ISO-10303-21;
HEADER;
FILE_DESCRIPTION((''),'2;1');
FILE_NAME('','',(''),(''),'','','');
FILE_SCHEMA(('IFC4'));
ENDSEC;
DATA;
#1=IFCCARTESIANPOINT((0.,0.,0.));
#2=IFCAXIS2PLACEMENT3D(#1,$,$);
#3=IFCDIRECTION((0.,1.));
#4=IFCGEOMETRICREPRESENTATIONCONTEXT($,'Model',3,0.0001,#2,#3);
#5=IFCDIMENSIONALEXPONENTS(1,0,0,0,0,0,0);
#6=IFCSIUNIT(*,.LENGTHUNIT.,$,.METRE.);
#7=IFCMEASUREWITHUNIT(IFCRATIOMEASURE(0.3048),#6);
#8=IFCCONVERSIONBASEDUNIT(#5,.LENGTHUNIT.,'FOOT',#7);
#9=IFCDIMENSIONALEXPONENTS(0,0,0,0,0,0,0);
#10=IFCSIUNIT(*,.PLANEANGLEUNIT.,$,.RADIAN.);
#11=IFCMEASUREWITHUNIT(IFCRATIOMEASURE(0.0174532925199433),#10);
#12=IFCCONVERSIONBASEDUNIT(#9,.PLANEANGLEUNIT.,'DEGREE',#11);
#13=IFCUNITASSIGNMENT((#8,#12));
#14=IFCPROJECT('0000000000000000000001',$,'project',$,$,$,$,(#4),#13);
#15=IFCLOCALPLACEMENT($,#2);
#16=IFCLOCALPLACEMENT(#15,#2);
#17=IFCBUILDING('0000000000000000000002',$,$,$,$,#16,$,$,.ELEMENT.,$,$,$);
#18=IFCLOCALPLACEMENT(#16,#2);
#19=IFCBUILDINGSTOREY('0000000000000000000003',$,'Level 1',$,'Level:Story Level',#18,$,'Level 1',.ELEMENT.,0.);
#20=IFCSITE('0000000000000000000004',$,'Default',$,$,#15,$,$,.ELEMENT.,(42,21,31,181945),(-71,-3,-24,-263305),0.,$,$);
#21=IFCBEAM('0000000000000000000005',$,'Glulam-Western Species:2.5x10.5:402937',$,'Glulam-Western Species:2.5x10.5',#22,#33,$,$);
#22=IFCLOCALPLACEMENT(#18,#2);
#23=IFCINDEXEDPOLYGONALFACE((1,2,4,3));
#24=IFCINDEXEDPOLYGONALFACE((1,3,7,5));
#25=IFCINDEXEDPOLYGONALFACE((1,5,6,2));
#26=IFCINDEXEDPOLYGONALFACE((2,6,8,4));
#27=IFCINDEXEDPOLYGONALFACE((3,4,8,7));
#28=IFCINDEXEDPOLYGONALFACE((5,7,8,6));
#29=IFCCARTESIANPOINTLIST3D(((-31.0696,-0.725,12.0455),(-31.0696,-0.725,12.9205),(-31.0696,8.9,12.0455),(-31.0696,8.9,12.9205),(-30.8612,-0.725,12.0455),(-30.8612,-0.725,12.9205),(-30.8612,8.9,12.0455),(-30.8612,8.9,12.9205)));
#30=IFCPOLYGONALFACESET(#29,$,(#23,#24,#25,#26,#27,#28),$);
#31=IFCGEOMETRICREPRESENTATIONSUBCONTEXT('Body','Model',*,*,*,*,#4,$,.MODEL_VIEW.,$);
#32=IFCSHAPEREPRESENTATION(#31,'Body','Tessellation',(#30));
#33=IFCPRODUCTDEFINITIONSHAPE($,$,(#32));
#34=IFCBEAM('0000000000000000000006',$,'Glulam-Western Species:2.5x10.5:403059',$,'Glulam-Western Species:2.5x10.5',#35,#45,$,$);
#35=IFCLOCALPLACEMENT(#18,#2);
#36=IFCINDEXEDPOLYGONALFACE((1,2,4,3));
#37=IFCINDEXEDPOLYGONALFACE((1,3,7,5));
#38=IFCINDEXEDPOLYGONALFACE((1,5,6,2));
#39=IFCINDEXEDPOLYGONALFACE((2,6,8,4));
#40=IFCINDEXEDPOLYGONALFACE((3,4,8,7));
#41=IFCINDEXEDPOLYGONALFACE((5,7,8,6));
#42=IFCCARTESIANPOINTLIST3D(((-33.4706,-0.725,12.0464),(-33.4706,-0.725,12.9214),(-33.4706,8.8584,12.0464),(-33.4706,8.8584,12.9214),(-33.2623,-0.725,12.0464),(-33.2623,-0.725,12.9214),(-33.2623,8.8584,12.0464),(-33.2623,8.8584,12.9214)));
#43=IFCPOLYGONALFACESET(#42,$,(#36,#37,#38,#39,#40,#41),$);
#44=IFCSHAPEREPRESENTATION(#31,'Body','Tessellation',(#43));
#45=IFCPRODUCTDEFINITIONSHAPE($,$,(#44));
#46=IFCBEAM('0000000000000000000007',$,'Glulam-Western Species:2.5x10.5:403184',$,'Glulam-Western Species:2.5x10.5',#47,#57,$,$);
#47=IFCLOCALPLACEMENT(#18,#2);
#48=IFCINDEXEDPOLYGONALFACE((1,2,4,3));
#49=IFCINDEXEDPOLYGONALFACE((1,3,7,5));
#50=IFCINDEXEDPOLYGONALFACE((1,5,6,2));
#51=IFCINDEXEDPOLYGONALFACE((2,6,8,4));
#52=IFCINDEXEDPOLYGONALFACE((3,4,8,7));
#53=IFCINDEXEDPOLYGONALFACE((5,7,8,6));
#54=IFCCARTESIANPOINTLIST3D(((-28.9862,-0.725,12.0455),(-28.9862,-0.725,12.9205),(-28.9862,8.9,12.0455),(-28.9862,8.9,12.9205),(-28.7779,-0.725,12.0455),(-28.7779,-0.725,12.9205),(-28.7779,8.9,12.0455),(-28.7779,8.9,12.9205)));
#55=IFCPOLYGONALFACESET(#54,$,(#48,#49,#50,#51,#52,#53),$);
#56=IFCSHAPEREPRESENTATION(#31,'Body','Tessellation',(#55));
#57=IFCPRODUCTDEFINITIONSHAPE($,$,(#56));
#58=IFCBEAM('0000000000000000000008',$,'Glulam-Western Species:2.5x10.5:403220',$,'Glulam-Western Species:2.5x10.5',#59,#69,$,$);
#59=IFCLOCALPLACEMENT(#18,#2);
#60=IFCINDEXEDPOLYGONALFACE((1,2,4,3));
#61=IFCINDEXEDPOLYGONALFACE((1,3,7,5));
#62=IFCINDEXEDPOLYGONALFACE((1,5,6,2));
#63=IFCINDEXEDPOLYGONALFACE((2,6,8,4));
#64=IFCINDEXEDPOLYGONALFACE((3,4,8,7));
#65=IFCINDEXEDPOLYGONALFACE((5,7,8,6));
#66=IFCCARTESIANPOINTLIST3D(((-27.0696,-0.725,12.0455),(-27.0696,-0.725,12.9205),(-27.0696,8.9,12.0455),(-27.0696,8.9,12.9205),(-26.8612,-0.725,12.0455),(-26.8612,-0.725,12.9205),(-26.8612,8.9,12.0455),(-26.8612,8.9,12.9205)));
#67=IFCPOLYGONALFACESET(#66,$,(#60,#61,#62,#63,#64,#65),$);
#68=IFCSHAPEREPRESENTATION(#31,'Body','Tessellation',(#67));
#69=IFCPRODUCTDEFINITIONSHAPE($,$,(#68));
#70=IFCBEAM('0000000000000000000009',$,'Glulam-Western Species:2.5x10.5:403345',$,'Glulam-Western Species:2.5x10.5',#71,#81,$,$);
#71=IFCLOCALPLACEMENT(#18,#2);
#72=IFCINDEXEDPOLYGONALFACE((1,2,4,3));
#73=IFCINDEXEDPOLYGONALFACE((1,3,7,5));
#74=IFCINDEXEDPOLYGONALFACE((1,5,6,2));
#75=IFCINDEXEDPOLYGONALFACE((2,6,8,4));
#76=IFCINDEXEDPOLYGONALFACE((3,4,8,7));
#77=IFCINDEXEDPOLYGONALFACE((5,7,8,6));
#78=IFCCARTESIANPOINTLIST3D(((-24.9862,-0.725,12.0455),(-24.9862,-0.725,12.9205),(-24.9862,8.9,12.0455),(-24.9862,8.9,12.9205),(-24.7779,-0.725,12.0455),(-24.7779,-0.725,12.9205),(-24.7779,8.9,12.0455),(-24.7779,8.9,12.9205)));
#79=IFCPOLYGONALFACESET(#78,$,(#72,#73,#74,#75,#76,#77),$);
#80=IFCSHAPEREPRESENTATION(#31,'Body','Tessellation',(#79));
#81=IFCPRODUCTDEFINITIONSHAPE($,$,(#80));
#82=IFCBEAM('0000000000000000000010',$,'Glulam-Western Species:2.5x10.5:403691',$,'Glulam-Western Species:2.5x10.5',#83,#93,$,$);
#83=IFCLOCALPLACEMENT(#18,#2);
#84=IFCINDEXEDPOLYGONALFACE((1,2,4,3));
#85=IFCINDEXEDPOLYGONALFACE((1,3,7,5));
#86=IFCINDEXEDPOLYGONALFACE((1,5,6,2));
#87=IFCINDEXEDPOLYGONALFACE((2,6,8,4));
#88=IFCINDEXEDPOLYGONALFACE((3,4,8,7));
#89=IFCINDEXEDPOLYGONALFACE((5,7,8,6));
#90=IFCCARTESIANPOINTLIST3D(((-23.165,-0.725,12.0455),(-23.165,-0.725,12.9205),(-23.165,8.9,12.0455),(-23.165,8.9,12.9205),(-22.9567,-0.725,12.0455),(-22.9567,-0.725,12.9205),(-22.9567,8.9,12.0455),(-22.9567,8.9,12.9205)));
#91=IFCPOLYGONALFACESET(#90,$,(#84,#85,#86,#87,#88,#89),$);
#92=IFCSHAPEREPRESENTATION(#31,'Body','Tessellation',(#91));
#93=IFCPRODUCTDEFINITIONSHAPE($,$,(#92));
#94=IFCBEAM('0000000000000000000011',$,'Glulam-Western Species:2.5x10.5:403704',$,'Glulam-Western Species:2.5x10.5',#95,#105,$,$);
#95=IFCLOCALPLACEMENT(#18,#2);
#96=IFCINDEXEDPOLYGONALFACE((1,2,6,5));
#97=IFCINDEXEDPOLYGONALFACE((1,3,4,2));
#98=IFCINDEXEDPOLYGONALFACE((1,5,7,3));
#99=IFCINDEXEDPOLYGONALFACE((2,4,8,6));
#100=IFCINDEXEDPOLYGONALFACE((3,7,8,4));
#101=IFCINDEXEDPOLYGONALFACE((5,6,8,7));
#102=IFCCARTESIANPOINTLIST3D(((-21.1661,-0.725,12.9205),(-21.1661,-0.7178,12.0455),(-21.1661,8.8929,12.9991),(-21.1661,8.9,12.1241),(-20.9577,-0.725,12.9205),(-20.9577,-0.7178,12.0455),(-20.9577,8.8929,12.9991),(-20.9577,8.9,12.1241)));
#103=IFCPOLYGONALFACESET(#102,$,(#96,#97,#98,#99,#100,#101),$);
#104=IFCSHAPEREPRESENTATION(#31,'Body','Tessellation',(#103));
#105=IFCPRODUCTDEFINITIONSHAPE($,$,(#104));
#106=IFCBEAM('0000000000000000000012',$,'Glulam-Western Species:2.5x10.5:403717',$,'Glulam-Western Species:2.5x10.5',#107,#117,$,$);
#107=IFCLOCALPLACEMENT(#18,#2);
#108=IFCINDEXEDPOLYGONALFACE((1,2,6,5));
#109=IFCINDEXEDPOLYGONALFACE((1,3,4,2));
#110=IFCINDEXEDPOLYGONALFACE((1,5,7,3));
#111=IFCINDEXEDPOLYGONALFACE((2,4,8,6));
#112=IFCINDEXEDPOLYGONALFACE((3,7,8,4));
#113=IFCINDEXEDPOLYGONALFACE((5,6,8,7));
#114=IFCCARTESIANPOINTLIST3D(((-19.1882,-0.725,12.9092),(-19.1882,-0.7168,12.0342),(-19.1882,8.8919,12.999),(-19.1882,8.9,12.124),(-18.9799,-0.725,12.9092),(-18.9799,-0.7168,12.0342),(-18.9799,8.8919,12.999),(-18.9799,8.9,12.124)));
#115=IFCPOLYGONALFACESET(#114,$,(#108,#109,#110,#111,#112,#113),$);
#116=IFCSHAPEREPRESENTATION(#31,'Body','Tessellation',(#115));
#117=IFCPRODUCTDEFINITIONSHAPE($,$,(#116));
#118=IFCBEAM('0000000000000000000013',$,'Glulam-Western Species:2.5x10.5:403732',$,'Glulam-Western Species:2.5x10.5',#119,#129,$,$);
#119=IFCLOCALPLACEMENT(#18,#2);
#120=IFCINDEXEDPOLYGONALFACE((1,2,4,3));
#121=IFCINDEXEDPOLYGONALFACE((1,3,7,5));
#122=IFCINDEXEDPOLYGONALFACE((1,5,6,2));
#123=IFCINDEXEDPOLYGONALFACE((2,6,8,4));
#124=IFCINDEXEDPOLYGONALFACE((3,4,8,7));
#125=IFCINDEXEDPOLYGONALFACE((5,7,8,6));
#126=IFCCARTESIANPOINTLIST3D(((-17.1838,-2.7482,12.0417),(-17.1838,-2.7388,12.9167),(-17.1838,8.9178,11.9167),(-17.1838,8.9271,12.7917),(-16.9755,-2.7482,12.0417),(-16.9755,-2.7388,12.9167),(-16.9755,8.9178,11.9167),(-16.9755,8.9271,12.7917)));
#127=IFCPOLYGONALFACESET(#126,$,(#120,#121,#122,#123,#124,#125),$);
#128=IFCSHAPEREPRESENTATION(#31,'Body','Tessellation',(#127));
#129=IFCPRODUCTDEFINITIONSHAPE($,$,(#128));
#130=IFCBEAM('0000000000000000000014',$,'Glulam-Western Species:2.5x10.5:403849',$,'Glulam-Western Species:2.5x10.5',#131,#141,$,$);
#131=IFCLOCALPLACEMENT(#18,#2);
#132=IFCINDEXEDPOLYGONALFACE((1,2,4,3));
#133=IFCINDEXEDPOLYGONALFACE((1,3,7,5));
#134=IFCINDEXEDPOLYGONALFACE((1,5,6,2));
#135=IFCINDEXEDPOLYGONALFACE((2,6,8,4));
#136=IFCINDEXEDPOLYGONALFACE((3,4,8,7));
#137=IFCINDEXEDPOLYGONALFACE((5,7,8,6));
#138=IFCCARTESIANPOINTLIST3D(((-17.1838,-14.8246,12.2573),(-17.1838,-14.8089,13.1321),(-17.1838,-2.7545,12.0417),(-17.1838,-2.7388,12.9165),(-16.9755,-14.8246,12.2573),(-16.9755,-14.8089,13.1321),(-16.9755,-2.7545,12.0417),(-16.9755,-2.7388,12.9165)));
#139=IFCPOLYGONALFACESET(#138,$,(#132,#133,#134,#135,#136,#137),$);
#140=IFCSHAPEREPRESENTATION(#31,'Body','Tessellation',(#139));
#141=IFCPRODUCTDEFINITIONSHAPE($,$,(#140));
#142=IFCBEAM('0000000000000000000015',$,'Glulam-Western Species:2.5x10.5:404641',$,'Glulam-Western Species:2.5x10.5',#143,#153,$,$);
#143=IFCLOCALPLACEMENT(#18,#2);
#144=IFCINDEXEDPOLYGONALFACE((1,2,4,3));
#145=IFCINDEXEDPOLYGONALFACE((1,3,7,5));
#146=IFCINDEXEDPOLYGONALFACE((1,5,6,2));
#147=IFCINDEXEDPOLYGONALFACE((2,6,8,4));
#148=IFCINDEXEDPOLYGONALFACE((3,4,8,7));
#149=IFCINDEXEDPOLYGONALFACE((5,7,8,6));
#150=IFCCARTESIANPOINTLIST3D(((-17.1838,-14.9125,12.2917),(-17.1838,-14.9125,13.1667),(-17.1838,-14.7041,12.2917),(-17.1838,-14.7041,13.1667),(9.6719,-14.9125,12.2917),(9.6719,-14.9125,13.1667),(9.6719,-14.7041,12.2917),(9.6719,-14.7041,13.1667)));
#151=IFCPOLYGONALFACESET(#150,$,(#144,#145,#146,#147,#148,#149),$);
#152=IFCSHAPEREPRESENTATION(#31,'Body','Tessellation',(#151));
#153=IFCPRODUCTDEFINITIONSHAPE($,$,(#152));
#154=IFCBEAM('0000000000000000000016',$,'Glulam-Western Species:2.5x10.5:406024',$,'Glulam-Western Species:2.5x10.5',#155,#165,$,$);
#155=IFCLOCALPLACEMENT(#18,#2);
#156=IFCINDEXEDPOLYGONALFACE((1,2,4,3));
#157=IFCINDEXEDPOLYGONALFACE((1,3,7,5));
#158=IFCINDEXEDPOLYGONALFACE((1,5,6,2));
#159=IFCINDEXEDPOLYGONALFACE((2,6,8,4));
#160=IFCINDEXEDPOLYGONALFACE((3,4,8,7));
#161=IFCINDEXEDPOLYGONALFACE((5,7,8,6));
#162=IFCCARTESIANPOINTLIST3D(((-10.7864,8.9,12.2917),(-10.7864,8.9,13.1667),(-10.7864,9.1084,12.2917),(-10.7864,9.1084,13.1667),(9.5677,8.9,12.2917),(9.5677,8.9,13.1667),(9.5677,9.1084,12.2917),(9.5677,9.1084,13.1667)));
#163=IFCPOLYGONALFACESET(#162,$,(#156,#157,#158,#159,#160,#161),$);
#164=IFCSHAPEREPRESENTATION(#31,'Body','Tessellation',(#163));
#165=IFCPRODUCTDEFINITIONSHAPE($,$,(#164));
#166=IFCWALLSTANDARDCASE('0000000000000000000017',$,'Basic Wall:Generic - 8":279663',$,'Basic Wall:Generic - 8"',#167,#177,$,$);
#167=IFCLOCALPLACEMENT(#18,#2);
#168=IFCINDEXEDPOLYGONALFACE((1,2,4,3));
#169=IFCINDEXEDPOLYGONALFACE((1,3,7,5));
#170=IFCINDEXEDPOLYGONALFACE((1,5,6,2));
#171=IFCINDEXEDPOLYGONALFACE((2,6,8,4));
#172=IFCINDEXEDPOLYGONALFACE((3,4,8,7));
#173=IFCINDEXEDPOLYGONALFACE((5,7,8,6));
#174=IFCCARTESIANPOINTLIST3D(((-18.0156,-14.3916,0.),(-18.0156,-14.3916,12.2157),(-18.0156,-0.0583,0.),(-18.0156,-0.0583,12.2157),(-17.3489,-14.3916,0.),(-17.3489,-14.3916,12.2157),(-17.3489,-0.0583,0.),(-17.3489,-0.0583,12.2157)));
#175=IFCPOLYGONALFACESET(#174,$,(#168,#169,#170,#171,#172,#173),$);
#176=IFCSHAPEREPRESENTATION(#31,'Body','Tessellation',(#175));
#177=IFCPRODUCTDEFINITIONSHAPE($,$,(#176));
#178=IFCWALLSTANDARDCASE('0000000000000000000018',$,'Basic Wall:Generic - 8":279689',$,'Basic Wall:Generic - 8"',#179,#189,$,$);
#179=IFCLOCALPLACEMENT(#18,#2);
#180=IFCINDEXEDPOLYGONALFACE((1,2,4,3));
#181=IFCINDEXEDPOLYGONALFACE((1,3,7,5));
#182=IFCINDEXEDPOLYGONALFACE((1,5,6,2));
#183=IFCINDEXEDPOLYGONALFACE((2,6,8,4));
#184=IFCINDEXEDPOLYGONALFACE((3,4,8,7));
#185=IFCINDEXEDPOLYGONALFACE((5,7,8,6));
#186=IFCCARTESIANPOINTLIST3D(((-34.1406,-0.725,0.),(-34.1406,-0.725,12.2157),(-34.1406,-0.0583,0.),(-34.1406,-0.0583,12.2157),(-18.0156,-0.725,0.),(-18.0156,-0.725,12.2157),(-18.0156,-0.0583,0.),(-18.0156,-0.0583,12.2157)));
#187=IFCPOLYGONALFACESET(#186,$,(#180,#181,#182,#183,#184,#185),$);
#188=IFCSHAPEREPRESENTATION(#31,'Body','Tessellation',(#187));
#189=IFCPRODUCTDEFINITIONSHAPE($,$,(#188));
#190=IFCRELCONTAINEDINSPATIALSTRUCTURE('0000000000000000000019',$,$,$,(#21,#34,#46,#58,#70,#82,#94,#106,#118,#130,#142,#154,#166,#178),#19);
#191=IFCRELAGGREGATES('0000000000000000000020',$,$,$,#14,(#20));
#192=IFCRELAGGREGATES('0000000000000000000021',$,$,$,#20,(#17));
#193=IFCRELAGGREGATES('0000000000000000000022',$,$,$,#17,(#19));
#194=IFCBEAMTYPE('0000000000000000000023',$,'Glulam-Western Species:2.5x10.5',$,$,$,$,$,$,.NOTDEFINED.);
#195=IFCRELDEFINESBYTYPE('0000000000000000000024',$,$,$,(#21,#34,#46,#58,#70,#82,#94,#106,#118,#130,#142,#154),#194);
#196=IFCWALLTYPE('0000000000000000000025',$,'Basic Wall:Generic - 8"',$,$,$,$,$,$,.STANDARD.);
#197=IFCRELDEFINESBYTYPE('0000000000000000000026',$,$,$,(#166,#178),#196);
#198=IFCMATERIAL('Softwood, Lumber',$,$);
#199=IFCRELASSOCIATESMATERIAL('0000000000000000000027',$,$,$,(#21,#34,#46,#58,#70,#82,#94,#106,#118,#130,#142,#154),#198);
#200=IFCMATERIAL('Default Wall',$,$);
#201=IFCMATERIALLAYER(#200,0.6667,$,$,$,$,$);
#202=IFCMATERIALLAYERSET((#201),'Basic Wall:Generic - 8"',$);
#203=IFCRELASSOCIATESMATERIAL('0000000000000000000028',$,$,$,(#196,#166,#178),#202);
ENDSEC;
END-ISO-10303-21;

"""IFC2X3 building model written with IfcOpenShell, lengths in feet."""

from ifc_helpers import new_model, entity, si_unit, converted_unit, direction, frame, frame_2d, origin, origin_2d_with_axis, place, context, subcontext, project, spatial, rectangle, extrude, material, layer, layer_set, layer_usage, type_object, element, save


model = new_model("IFC2X3")

# Units and contexts
model_context = context("Model", 3, precision=0.0001, world=origin(), true_north=direction((0.0, 1.0)))
body_context = subcontext(model_context, "Body", "Model", "MODEL_VIEW")
ifc_project = project(units=[converted_unit("LENGTHUNIT", "FOOT", entity("IfcRatioMeasure", 0.3048), si_unit("LENGTHUNIT", "METRE"), dimensions=[1, 0, 0, 0, 0, 0, 0]), converted_unit("PLANEANGLEUNIT", "DEGREE", entity("IfcRatioMeasure", 0.0174532925199433), si_unit("PLANEANGLEUNIT", "RADIAN"), dimensions=[0, 0, 0, 0, 0, 0, 0])], contexts=[model_context])

# Site, building, storey
site_placement = place(None, origin())
site = spatial("IfcSite", under=ifc_project, at=site_placement, Name="Default", CompositionType="ELEMENT", RefLatitude=(42, 21, 31, 181945), RefLongitude=(-71, -3, -24, -263305), RefElevation=0.0)
building_placement = place(site_placement, origin())
building = spatial("IfcBuilding", under=site, at=building_placement, CompositionType="ELEMENT")
storey_placement = place(building_placement, origin())
storey = spatial("IfcBuildingStorey", under=building, at=storey_placement, Name="Level 1", ObjectType="Level:Story Level", LongName="Level 1", CompositionType="ELEMENT", Elevation=0.0)

# Beams
ifc_material_1 = material(Name="Softwood, Lumber")
beam_type = type_object("IfcBeamType", Name="Glulam-Western Species:2.5x10.5", PredefinedType="NOTDEFINED")
beam_1_placement = place(storey_placement, frame((-30.9654, 8.6084, 12.9205), z_axis=(0.0, 0.0, 1.0), x_axis=(0.0, -1.0, 0.0)))
element("IfcBeam", 1, at=beam_1_placement, inside=storey, type_object=beam_type, material=ifc_material_1, Name="Glulam-Western Species:2.5x10.5:402937", ObjectType="Glulam-Western Species:2.5x10.5", context=body_context, shape_type="SweptSolid", body=[
    extrude(rectangle(XDim=0.875, YDim=0.2083, at=frame_2d((0.0, 0.0), x_axis=(1.0, 0.0))), frame((-0.2917, 0.0, -0.4375), z_axis=(1.0, 0.0, 0.0), x_axis=(0.0, 0.0, -1.0)), (0.0, 0.0, 1.0), 9.625),
])
beam_2_placement = place(storey_placement, frame((-33.3665, 8.8584, 12.9214), z_axis=(0.0, 0.0, 1.0), x_axis=(0.0, -1.0, 0.0)))
element("IfcBeam", 2, at=beam_2_placement, inside=storey, type_object=beam_type, material=ifc_material_1, Name="Glulam-Western Species:2.5x10.5:403059", ObjectType="Glulam-Western Species:2.5x10.5", context=body_context, shape_type="SweptSolid", body=[
    extrude(rectangle(XDim=0.875, YDim=0.2083, at=frame_2d((0.0, 0.0), x_axis=(1.0, 0.0))), frame((0.0, 0.0, -0.4375), z_axis=(1.0, 0.0, 0.0), x_axis=(0.0, 0.0, -1.0)), (0.0, 0.0, 1.0), 9.5833),
])
beam_3_placement = place(storey_placement, frame((-28.8821, 8.6084, 12.9205), z_axis=(0.0, 0.0, 1.0), x_axis=(0.0, -1.0, 0.0)))
element("IfcBeam", 3, at=beam_3_placement, inside=storey, type_object=beam_type, material=ifc_material_1, Name="Glulam-Western Species:2.5x10.5:403184", ObjectType="Glulam-Western Species:2.5x10.5", context=body_context, shape_type="SweptSolid", body=[
    extrude(rectangle(XDim=0.875, YDim=0.2083, at=frame_2d((0.0, 0.0), x_axis=(1.0, 0.0))), frame((-0.2917, 0.0, -0.4375), z_axis=(1.0, 0.0, 0.0), x_axis=(0.0, 0.0, -1.0)), (0.0, 0.0, 1.0), 9.625),
])
for number, where, z_axis, x_axis, name in (
    (4, (-26.9654, 8.6084, 12.9205), (0.0, 0.0, 1.0), (0.0, -1.0, 0.0), "Glulam-Western Species:2.5x10.5:403220"),
    (5, (-24.8821, 8.6084, 12.9205), (0.0, 0.0, 1.0), (0.0, -1.0, 0.0), "Glulam-Western Species:2.5x10.5:403345"),
    (6, (-23.0608, 8.6084, 12.9205), (0.0, 0.0, 1.0), (0.0, -1.0, 0.0), "Glulam-Western Species:2.5x10.5:403691"),
):
    element("IfcBeam", number, at=place(storey_placement, frame(where, z_axis=z_axis, x_axis=x_axis)), inside=storey, type_object=beam_type, material=ifc_material_1, Name=name, ObjectType="Glulam-Western Species:2.5x10.5", context=body_context, shape_type="SweptSolid", body=[
        extrude(rectangle(XDim=0.875, YDim=0.2083, at=frame_2d((0.0, 0.0), x_axis=(1.0, 0.0))), frame((-0.2917, 0.0, -0.4375), z_axis=(1.0, 0.0, 0.0), x_axis=(0.0, 0.0, -1.0)), (0.0, 0.0, 1.0), 9.625),
    ])
beam_4_placement = place(storey_placement, frame((-21.0619, 9.0042, 13.0), z_axis=(0.0, -0.008173, 0.999967), x_axis=(0.0, -0.999967, -0.008173)))
element("IfcBeam", 7, at=beam_4_placement, inside=storey, type_object=beam_type, material=ifc_material_1, Name="Glulam-Western Species:2.5x10.5:403704", ObjectType="Glulam-Western Species:2.5x10.5", context=body_context, shape_type="SweptSolid", body=[
    extrude(rectangle(XDim=0.875, YDim=0.2083, at=frame_2d((0.0, 0.0), x_axis=(1.0, 0.0))), frame((0.1113, 0.0, -0.4375), z_axis=(1.0, 0.0, 0.0), x_axis=(0.0, 0.0, -1.0)), (0.0, 0.0, 1.0), 9.6182),
])
beam_5_placement = place(storey_placement, frame((-19.084, 9.0042, 13.0), z_axis=(0.0, -0.009334, 0.999956), x_axis=(0.0, -0.999956, -0.009334)))
element("IfcBeam", 8, at=beam_5_placement, inside=storey, type_object=beam_type, material=ifc_material_1, Name="Glulam-Western Species:2.5x10.5:403717", ObjectType="Glulam-Western Species:2.5x10.5", context=body_context, shape_type="SweptSolid", body=[
    extrude(rectangle(XDim=0.875, YDim=0.2083, at=frame_2d((0.0, 0.0), x_axis=(1.0, 0.0))), frame((0.1123, 0.0, -0.4375), z_axis=(1.0, 0.0, 0.0), x_axis=(0.0, 0.0, -1.0)), (0.0, 0.0, 1.0), 9.6173),
])
beam_6_placement = place(storey_placement, frame((-17.0796, 8.9271, 12.7917), z_axis=(0.0, 0.010714, 0.999943), x_axis=(0.0, -0.999943, 0.010714)))
element("IfcBeam", 9, at=beam_6_placement, inside=storey, type_object=beam_type, material=ifc_material_1, Name="Glulam-Western Species:2.5x10.5:403732", ObjectType="Glulam-Western Species:2.5x10.5", context=body_context, shape_type="SweptSolid", body=[
    extrude(rectangle(XDim=0.875, YDim=0.2083, at=origin_2d_with_axis()), frame((0.0, 0.0, -0.4375), z_axis=(1.0, 0.0, 0.0), x_axis=(0.0, 0.0, -1.0)), (0.0, 0.0, 1.0), 11.6667),
])
beam_7_placement = place(storey_placement, frame((-17.0796, -2.7563, 12.9169), z_axis=(0.0, 0.017857, 0.999841), x_axis=(0.0, -0.999841, 0.017857)))
element("IfcBeam", 10, at=beam_7_placement, inside=storey, type_object=beam_type, material=ifc_material_1, Name="Glulam-Western Species:2.5x10.5:403849", ObjectType="Glulam-Western Species:2.5x10.5", context=body_context, shape_type="SweptSolid", body=[
    extrude(rectangle(XDim=0.875, YDim=0.2083, at=frame_2d((0.0, 0.0), x_axis=(1.0, 0.0))), frame((-0.0174, 0.0, -0.4375), z_axis=(1.0, 0.0, 0.0), x_axis=(0.0, 0.0, -1.0)), (0.0, 0.0, 1.0), 12.072),
])
beam_8_placement = place(storey_placement, frame((-17.3073, -14.8083, 13.1667)))
element("IfcBeam", 11, at=beam_8_placement, inside=storey, type_object=beam_type, material=ifc_material_1, Name="Glulam-Western Species:2.5x10.5:404641", ObjectType="Glulam-Western Species:2.5x10.5", context=body_context, shape_type="SweptSolid", body=[
    extrude(rectangle(XDim=0.875, YDim=0.2083, at=frame_2d((0.0, 0.0), x_axis=(1.0, 0.0))), frame((0.1235, 0.0, -0.4375), z_axis=(1.0, 0.0, 0.0), x_axis=(0.0, 0.0, -1.0)), (0.0, 0.0, 1.0), 26.8557),
])
beam_9_placement = place(storey_placement, frame((-17.4114, 9.0042, 13.1667)))
element("IfcBeam", 12, at=beam_9_placement, inside=storey, type_object=beam_type, material=ifc_material_1, Name="Glulam-Western Species:2.5x10.5:406024", ObjectType="Glulam-Western Species:2.5x10.5", context=body_context, shape_type="SweptSolid", body=[
    extrude(rectangle(XDim=0.875, YDim=0.2083, at=frame_2d((0.0, 0.0), x_axis=(1.0, 0.0))), frame((6.625, 0.0, -0.4375), z_axis=(1.0, 0.0, 0.0), x_axis=(0.0, 0.0, -1.0)), (0.0, 0.0, 1.0), 20.3542),
])

# Walls
ifc_material_2 = material(Name="Default Wall")
ifc_layer = layer(ifc_material_2, 0.6667)
ifc_layer_set = layer_set([ifc_layer], Name="Basic Wall:Generic - 8\"")
ifc_layer_usage_1 = layer_usage(ifc_layer_set, "AXIS2", "NEGATIVE", 0.3333)
wall_type = type_object("IfcWallType", Name="Basic Wall:Generic - 8\"", PredefinedType="STANDARD", material=ifc_layer_set)
wall_1_placement = place(storey_placement, frame((-17.6823, -14.3916, 0.0), z_axis=(0.0, 0.0, 1.0), x_axis=(0.0, 1.0, 0.0)))
element("IfcWallStandardCase", 13, at=wall_1_placement, inside=storey, type_object=wall_type, material=ifc_layer_usage_1, Name="Basic Wall:Generic - 8\":279663", ObjectType="Basic Wall:Generic - 8\"", context=body_context, shape_type="SweptSolid", body=[
    extrude(rectangle(XDim=14.3333, YDim=0.6667, at=frame_2d((7.1667, 0.0), x_axis=(-1.0, 0.0))), origin(), (0.0, 0.0, 1.0), 12.2157),
])
ifc_layer_usage_2 = layer_usage(ifc_layer_set, "AXIS2", "NEGATIVE", 0.3333)
wall_2_placement = place(storey_placement, frame((-18.0156, -0.3916, 0.0), z_axis=(0.0, 0.0, 1.0), x_axis=(-1.0, 0.0, 0.0)))
element("IfcWallStandardCase", 14, at=wall_2_placement, inside=storey, type_object=wall_type, material=ifc_layer_usage_2, Name="Basic Wall:Generic - 8\":279689", ObjectType="Basic Wall:Generic - 8\"", context=body_context, shape_type="SweptSolid", body=[
    extrude(rectangle(XDim=16.125, YDim=0.6667, at=frame_2d((8.0625, 0.0), x_axis=(-1.0, 0.0))), origin(), (0.0, 0.0, 1.0), 12.2157),
])

save(model, "model.ifc")
